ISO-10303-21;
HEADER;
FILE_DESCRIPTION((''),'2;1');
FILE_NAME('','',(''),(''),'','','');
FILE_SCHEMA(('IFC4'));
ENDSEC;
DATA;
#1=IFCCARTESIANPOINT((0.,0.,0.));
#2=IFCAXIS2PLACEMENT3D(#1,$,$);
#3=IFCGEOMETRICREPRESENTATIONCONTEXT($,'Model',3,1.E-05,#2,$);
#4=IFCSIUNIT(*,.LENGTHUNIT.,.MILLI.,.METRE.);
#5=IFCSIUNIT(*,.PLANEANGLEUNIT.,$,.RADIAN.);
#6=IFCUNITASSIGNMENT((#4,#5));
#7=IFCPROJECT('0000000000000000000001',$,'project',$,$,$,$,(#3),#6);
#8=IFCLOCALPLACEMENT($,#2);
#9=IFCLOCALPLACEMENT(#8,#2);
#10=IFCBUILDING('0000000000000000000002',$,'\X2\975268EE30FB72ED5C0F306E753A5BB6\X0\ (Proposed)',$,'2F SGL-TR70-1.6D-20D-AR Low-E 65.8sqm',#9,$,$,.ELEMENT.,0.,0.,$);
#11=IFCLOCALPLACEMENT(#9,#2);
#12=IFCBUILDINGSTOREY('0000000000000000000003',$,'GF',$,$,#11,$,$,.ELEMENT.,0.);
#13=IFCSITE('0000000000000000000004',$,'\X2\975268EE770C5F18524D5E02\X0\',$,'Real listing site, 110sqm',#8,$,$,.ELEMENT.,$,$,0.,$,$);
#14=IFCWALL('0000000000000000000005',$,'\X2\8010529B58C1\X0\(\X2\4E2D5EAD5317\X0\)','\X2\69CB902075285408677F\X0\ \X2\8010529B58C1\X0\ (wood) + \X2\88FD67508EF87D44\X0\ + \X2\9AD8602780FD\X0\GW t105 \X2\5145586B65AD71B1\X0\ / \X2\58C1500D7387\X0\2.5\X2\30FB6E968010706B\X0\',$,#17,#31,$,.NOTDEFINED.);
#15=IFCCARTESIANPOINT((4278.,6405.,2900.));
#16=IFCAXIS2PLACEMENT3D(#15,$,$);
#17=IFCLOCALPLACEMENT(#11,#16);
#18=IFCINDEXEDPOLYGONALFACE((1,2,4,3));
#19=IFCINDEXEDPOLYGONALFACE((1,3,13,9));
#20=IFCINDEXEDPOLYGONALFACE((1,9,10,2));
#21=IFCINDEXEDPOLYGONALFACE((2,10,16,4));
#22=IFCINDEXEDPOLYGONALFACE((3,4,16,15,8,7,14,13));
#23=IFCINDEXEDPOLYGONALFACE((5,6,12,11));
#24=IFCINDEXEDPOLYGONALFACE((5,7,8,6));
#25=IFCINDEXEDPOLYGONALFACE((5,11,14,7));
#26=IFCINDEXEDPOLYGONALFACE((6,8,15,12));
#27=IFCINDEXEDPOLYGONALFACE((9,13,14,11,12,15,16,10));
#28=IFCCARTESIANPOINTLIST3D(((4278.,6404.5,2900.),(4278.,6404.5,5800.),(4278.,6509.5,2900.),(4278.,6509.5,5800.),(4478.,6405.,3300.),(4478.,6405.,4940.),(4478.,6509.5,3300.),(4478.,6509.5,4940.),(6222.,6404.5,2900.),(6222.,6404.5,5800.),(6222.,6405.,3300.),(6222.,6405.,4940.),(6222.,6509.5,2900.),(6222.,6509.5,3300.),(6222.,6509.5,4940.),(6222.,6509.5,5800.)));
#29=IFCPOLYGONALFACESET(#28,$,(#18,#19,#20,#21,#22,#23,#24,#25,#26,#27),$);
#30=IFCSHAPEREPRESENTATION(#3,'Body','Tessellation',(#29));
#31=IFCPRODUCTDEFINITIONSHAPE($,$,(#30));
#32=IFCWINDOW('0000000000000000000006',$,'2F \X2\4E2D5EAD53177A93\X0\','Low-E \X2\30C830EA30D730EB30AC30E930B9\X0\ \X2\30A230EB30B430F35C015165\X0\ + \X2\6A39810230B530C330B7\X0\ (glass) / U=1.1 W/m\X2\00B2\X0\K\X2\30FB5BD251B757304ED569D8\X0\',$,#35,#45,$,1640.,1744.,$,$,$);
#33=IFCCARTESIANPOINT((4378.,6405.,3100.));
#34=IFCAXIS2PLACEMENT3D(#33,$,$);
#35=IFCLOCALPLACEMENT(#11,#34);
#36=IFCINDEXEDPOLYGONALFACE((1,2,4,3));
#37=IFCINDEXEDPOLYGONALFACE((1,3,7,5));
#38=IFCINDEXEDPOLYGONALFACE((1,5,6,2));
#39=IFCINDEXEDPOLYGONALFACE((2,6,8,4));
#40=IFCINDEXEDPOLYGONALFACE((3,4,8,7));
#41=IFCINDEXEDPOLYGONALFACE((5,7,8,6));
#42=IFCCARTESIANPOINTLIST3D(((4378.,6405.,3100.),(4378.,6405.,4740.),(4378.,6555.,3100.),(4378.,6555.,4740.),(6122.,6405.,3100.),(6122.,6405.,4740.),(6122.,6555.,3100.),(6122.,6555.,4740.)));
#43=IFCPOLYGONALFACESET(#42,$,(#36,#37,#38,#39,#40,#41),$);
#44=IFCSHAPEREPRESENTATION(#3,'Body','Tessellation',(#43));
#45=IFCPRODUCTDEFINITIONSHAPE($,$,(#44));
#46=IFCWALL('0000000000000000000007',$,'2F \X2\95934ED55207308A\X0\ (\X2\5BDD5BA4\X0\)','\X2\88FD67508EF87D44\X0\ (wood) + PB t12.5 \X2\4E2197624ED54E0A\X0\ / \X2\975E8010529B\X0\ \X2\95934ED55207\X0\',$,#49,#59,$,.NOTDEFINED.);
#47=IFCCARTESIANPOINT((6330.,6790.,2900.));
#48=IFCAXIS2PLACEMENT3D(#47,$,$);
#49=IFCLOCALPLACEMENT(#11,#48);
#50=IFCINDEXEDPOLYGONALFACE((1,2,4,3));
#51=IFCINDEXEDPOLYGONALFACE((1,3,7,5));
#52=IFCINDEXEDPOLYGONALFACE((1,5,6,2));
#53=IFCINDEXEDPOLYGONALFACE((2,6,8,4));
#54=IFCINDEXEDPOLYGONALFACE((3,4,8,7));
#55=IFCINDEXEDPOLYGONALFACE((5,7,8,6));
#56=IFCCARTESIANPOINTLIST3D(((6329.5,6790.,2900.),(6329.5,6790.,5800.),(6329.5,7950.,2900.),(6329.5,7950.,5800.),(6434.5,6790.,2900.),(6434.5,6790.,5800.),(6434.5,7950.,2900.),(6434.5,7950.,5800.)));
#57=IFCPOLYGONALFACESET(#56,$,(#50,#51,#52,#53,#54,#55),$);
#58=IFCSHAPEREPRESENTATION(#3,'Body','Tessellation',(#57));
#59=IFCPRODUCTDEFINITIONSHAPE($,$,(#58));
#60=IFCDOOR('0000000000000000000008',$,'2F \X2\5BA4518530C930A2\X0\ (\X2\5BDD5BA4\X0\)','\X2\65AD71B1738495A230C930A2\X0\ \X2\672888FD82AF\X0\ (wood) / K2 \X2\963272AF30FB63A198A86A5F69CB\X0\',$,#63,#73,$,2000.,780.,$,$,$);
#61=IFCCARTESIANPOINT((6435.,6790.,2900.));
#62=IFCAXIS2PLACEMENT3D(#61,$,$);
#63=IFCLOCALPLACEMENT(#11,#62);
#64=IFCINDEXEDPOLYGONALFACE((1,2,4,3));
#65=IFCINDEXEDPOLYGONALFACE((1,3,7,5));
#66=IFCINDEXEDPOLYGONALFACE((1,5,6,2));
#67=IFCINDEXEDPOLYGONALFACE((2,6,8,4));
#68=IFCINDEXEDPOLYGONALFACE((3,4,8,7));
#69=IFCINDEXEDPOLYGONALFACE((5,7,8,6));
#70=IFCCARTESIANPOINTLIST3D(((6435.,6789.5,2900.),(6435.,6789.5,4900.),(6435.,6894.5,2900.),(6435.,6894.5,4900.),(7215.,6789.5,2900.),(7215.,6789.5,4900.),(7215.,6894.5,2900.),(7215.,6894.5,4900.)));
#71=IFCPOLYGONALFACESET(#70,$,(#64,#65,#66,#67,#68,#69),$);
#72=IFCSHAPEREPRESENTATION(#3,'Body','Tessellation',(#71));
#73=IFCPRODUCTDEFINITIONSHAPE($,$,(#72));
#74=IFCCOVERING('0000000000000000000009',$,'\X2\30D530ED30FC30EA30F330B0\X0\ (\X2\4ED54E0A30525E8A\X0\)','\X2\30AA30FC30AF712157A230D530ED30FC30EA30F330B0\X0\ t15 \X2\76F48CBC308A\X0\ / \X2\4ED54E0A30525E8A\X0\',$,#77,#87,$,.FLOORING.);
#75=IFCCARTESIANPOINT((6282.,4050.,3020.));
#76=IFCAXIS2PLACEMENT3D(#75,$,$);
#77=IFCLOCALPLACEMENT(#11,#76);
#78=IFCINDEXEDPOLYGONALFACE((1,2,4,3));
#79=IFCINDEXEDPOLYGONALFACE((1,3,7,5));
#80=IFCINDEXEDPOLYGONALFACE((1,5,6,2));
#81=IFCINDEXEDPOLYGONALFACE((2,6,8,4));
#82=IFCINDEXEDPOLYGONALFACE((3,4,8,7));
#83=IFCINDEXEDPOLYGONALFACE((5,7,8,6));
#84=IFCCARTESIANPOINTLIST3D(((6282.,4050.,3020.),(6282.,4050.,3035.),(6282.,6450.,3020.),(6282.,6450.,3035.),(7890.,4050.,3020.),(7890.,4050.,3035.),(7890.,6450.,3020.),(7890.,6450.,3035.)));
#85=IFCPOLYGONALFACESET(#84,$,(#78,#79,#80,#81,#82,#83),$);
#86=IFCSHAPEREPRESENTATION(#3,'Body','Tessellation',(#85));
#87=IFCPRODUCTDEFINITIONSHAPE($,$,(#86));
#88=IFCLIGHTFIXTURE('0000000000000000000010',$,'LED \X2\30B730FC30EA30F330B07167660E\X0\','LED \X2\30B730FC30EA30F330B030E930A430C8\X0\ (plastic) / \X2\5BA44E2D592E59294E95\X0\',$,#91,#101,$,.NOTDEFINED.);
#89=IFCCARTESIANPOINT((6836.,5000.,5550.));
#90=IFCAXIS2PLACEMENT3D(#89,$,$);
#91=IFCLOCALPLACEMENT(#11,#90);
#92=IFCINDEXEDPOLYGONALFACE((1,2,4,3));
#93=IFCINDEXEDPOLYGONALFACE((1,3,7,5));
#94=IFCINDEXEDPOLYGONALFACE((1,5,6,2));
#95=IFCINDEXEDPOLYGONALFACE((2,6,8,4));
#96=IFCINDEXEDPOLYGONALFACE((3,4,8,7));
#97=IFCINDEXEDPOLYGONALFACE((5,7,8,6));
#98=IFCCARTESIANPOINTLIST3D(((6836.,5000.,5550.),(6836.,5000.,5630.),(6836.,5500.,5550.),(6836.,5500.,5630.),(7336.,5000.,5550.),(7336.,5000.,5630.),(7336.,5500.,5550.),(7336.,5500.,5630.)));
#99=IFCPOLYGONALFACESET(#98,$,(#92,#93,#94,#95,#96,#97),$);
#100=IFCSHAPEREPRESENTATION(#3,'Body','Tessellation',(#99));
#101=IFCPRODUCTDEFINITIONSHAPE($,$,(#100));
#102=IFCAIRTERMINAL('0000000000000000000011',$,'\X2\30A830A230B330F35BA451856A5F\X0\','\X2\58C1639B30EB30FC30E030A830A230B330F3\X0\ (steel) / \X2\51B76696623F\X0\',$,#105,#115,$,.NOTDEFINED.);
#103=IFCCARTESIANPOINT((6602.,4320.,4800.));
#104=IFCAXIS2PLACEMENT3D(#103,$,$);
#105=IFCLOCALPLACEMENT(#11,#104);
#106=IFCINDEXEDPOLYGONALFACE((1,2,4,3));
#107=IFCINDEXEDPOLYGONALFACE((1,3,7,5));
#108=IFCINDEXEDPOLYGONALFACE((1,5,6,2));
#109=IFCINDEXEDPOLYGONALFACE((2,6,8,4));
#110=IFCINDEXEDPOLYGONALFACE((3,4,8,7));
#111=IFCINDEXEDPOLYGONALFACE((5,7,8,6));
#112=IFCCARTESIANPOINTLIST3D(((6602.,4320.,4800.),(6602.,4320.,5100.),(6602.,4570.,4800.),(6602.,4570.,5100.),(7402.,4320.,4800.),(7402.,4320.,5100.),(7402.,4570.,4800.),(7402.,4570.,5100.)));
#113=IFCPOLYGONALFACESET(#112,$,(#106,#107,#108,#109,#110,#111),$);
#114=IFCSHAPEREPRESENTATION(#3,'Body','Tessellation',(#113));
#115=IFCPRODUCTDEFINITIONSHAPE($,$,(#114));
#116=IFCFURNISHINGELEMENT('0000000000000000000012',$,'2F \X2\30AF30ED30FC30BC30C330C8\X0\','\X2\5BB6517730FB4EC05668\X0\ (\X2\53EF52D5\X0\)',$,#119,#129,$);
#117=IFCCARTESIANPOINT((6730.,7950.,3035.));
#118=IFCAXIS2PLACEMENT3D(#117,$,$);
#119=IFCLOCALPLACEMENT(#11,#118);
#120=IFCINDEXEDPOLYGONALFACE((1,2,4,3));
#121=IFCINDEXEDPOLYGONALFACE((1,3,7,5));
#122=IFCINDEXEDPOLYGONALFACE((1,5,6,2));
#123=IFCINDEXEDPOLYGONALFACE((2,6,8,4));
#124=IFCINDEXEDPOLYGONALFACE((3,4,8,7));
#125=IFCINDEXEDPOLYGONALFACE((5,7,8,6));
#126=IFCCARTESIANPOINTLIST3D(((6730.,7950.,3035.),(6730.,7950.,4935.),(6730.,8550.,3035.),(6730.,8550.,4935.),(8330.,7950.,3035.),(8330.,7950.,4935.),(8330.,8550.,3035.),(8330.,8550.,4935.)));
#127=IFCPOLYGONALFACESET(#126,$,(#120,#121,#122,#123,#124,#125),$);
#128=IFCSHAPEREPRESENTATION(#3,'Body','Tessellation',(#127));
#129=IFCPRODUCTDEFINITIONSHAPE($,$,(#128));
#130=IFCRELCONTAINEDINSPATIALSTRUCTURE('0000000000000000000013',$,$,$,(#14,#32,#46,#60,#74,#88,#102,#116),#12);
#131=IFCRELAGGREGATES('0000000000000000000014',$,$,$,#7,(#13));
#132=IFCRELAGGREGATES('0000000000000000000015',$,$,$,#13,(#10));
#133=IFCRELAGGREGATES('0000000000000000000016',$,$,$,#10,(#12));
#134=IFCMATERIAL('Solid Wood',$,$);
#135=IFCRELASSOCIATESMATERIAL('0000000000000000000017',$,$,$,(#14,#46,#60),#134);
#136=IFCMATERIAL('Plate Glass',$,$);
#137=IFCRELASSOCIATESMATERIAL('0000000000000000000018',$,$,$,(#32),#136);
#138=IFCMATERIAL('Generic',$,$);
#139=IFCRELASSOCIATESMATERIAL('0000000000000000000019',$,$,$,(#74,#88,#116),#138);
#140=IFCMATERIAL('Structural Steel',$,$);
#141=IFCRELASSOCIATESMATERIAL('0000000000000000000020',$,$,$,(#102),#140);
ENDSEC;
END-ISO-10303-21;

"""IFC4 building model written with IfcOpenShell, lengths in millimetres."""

from ifc_helpers import new_model, si_unit, frame, frame_2d, origin, place, context, project, spatial, rectangle, extrude, material, element, fill, save


model = new_model("IFC4")

# Units and contexts
model_context = context("Model", 3, precision=1e-05, world=origin())
ifc_project = project(units=[si_unit("LENGTHUNIT", "METRE", prefix="MILLI"), si_unit("PLANEANGLEUNIT", "RADIAN")], contexts=[model_context])

# Site, building, storey
site_placement = place(None, origin())
site = spatial("IfcSite", under=ifc_project, at=site_placement, Name="青森県弘前市", ObjectType="Real listing site, 110sqm", CompositionType="ELEMENT", RefElevation=0.0)
building_placement = place(site_placement, origin())
building = spatial("IfcBuilding", under=site, at=building_placement, Name="青森・狭小の町家 (Proposed)", ObjectType="2F SGL-TR70-1.6D-20D-AR Low-E 65.8sqm", CompositionType="ELEMENT", ElevationOfRefHeight=0.0, ElevationOfTerrain=0.0)
storey_placement = place(building_placement, origin())
storey = spatial("IfcBuildingStorey", under=building, at=storey_placement, Name="GF", CompositionType="ELEMENT", Elevation=0.0)

# Shared definitions
ifc_material_1 = material(Name="Solid Wood")

# Wall, opening, window
wall_1_placement = place(storey_placement, frame((4278.0, 6405.0, 2900.0)))
wall_1 = element("IfcWall", 1, at=wall_1_placement, inside=storey, material=ifc_material_1, Name="耐力壁(中庭北)", Description="構造用合板 耐力壁 (wood) + 製材軸組 + 高性能GW t105 充填断熱 / 壁倍率2.5・準耐火", PredefinedType="NOTDEFINED", context=model_context, shape_type="SweptSolid", body=[
    extrude(rectangle(XDim=1944.0, YDim=105.0, at=frame_2d((972.0, 52.0))), frame((4278.0, 6405.0, 2900.0)), (0.0, 0.0, 1.0), 2900.0),
])
opening_placement = place(storey_placement, frame((4378.0, 6405.0, 3100.0)))
opening = element("IfcOpeningElement", 2, at=opening_placement, cuts=wall_1, PredefinedType="NOTDEFINED", context=model_context, shape_type="SweptSolid", body=[
    extrude(rectangle(XDim=1744.0, YDim=150.0, at=frame_2d((872.0, 75.0))), frame((4378.0, 6405.0, 3100.0)), (0.0, 0.0, 1.0), 1640.0),
])
ifc_material_2 = material(Name="Plate Glass")
window_placement = place(storey_placement, frame((4378.0, 6405.0, 3100.0)))
window = element("IfcWindow", 3, at=window_placement, inside=storey, material=ifc_material_2, Name="2F 中庭北窓", Description="Low-E トリプルガラス アルゴン封入 + 樹脂サッシ (glass) / U=1.1 W/m²K・寒冷地仕様", OverallHeight=1640.0, OverallWidth=1744.0, context=model_context, shape_type="SweptSolid", body=[
    extrude(rectangle(XDim=1744.0, YDim=150.0, at=frame_2d((872.0, 75.0))), frame((4378.0, 6405.0, 3100.0)), (0.0, 0.0, 1.0), 1640.0),
])
fill(opening, window)

# Wall
wall_2_placement = place(storey_placement, frame((6330.0, 6790.0, 2900.0)))
element("IfcWall", 4, at=wall_2_placement, inside=storey, material=ifc_material_1, Name="2F 間仕切り (寝室)", Description="製材軸組 (wood) + PB t12.5 両面仕上 / 非耐力 間仕切", PredefinedType="NOTDEFINED", context=model_context, shape_type="SweptSolid", body=[
    extrude(rectangle(XDim=105.0, YDim=1160.0, at=frame_2d((52.0, 580.0))), frame((6330.0, 6790.0, 2900.0)), (0.0, 0.0, 1.0), 2900.0),
])

# Door
door_placement = place(storey_placement, frame((6435.0, 6790.0, 2900.0)))
element("IfcDoor", 5, at=door_placement, inside=storey, material=ifc_material_1, Name="2F 室内ドア (寝室)", Description="断熱玄関ドア 木製芯 (wood) / K2 防犯・採風機構", OverallHeight=2000.0, OverallWidth=780.0, context=model_context, shape_type="SweptSolid", body=[
    extrude(rectangle(XDim=780.0, YDim=105.0, at=frame_2d((390.0, 52.0))), frame((6435.0, 6790.0, 2900.0)), (0.0, 0.0, 1.0), 2000.0),
])

# Covering
ifc_material_3 = material(Name="Generic")
covering_placement = place(storey_placement, frame((6282.0, 4050.0, 3020.0)))
element("IfcCovering", 6, at=covering_placement, inside=storey, material=ifc_material_3, Name="フローリング (仕上げ床)", Description="オーク無垢フローリング t15 直貼り / 仕上げ床", PredefinedType="FLOORING", context=model_context, shape_type="SweptSolid", body=[
    extrude(rectangle(XDim=1608.0, YDim=2400.0, at=frame_2d((804.0, 1200.0))), frame((6282.0, 4050.0, 3020.0)), (0.0, 0.0, 1.0), 15.0),
])

# Light fixture
light_fixture_placement = place(storey_placement, frame((6836.0, 5000.0, 5550.0)))
element("IfcLightFixture", 7, at=light_fixture_placement, inside=storey, material=ifc_material_3, Name="LED シーリング照明", Description="LED シーリングライト (plastic) / 室中央天井", PredefinedType="NOTDEFINED", context=model_context, shape_type="SweptSolid", body=[
    extrude(rectangle(XDim=500.0, YDim=500.0, at=frame_2d((250.0, 250.0))), frame((6836.0, 5000.0, 5550.0)), (0.0, 0.0, 1.0), 80.0),
])

# Air terminal
ifc_material_4 = material(Name="Structural Steel")
air_terminal_placement = place(storey_placement, frame((6602.0, 4320.0, 4800.0)))
element("IfcAirTerminal", 8, at=air_terminal_placement, inside=storey, material=ifc_material_4, Name="エアコン室内機", Description="壁掛ルームエアコン (steel) / 冷暖房", PredefinedType="NOTDEFINED", context=model_context, shape_type="SweptSolid", body=[
    extrude(rectangle(XDim=800.0, YDim=250.0, at=frame_2d((400.0, 125.0))), frame((6602.0, 4320.0, 4800.0)), (0.0, 0.0, 1.0), 300.0),
])

# Furnishing element
furnishing_placement = place(storey_placement, frame((6730.0, 7950.0, 3035.0)))
element("IfcFurnishingElement", 9, at=furnishing_placement, inside=storey, material=ifc_material_3, Name="2F クローゼット", Description="家具・什器 (可動)", context=model_context, shape_type="SweptSolid", body=[
    extrude(rectangle(XDim=1600.0, YDim=600.0, at=frame_2d((800.0, 300.0))), frame((6730.0, 7950.0, 3035.0)), (0.0, 0.0, 1.0), 1900.0),
])

save(model, "model.ifc")
